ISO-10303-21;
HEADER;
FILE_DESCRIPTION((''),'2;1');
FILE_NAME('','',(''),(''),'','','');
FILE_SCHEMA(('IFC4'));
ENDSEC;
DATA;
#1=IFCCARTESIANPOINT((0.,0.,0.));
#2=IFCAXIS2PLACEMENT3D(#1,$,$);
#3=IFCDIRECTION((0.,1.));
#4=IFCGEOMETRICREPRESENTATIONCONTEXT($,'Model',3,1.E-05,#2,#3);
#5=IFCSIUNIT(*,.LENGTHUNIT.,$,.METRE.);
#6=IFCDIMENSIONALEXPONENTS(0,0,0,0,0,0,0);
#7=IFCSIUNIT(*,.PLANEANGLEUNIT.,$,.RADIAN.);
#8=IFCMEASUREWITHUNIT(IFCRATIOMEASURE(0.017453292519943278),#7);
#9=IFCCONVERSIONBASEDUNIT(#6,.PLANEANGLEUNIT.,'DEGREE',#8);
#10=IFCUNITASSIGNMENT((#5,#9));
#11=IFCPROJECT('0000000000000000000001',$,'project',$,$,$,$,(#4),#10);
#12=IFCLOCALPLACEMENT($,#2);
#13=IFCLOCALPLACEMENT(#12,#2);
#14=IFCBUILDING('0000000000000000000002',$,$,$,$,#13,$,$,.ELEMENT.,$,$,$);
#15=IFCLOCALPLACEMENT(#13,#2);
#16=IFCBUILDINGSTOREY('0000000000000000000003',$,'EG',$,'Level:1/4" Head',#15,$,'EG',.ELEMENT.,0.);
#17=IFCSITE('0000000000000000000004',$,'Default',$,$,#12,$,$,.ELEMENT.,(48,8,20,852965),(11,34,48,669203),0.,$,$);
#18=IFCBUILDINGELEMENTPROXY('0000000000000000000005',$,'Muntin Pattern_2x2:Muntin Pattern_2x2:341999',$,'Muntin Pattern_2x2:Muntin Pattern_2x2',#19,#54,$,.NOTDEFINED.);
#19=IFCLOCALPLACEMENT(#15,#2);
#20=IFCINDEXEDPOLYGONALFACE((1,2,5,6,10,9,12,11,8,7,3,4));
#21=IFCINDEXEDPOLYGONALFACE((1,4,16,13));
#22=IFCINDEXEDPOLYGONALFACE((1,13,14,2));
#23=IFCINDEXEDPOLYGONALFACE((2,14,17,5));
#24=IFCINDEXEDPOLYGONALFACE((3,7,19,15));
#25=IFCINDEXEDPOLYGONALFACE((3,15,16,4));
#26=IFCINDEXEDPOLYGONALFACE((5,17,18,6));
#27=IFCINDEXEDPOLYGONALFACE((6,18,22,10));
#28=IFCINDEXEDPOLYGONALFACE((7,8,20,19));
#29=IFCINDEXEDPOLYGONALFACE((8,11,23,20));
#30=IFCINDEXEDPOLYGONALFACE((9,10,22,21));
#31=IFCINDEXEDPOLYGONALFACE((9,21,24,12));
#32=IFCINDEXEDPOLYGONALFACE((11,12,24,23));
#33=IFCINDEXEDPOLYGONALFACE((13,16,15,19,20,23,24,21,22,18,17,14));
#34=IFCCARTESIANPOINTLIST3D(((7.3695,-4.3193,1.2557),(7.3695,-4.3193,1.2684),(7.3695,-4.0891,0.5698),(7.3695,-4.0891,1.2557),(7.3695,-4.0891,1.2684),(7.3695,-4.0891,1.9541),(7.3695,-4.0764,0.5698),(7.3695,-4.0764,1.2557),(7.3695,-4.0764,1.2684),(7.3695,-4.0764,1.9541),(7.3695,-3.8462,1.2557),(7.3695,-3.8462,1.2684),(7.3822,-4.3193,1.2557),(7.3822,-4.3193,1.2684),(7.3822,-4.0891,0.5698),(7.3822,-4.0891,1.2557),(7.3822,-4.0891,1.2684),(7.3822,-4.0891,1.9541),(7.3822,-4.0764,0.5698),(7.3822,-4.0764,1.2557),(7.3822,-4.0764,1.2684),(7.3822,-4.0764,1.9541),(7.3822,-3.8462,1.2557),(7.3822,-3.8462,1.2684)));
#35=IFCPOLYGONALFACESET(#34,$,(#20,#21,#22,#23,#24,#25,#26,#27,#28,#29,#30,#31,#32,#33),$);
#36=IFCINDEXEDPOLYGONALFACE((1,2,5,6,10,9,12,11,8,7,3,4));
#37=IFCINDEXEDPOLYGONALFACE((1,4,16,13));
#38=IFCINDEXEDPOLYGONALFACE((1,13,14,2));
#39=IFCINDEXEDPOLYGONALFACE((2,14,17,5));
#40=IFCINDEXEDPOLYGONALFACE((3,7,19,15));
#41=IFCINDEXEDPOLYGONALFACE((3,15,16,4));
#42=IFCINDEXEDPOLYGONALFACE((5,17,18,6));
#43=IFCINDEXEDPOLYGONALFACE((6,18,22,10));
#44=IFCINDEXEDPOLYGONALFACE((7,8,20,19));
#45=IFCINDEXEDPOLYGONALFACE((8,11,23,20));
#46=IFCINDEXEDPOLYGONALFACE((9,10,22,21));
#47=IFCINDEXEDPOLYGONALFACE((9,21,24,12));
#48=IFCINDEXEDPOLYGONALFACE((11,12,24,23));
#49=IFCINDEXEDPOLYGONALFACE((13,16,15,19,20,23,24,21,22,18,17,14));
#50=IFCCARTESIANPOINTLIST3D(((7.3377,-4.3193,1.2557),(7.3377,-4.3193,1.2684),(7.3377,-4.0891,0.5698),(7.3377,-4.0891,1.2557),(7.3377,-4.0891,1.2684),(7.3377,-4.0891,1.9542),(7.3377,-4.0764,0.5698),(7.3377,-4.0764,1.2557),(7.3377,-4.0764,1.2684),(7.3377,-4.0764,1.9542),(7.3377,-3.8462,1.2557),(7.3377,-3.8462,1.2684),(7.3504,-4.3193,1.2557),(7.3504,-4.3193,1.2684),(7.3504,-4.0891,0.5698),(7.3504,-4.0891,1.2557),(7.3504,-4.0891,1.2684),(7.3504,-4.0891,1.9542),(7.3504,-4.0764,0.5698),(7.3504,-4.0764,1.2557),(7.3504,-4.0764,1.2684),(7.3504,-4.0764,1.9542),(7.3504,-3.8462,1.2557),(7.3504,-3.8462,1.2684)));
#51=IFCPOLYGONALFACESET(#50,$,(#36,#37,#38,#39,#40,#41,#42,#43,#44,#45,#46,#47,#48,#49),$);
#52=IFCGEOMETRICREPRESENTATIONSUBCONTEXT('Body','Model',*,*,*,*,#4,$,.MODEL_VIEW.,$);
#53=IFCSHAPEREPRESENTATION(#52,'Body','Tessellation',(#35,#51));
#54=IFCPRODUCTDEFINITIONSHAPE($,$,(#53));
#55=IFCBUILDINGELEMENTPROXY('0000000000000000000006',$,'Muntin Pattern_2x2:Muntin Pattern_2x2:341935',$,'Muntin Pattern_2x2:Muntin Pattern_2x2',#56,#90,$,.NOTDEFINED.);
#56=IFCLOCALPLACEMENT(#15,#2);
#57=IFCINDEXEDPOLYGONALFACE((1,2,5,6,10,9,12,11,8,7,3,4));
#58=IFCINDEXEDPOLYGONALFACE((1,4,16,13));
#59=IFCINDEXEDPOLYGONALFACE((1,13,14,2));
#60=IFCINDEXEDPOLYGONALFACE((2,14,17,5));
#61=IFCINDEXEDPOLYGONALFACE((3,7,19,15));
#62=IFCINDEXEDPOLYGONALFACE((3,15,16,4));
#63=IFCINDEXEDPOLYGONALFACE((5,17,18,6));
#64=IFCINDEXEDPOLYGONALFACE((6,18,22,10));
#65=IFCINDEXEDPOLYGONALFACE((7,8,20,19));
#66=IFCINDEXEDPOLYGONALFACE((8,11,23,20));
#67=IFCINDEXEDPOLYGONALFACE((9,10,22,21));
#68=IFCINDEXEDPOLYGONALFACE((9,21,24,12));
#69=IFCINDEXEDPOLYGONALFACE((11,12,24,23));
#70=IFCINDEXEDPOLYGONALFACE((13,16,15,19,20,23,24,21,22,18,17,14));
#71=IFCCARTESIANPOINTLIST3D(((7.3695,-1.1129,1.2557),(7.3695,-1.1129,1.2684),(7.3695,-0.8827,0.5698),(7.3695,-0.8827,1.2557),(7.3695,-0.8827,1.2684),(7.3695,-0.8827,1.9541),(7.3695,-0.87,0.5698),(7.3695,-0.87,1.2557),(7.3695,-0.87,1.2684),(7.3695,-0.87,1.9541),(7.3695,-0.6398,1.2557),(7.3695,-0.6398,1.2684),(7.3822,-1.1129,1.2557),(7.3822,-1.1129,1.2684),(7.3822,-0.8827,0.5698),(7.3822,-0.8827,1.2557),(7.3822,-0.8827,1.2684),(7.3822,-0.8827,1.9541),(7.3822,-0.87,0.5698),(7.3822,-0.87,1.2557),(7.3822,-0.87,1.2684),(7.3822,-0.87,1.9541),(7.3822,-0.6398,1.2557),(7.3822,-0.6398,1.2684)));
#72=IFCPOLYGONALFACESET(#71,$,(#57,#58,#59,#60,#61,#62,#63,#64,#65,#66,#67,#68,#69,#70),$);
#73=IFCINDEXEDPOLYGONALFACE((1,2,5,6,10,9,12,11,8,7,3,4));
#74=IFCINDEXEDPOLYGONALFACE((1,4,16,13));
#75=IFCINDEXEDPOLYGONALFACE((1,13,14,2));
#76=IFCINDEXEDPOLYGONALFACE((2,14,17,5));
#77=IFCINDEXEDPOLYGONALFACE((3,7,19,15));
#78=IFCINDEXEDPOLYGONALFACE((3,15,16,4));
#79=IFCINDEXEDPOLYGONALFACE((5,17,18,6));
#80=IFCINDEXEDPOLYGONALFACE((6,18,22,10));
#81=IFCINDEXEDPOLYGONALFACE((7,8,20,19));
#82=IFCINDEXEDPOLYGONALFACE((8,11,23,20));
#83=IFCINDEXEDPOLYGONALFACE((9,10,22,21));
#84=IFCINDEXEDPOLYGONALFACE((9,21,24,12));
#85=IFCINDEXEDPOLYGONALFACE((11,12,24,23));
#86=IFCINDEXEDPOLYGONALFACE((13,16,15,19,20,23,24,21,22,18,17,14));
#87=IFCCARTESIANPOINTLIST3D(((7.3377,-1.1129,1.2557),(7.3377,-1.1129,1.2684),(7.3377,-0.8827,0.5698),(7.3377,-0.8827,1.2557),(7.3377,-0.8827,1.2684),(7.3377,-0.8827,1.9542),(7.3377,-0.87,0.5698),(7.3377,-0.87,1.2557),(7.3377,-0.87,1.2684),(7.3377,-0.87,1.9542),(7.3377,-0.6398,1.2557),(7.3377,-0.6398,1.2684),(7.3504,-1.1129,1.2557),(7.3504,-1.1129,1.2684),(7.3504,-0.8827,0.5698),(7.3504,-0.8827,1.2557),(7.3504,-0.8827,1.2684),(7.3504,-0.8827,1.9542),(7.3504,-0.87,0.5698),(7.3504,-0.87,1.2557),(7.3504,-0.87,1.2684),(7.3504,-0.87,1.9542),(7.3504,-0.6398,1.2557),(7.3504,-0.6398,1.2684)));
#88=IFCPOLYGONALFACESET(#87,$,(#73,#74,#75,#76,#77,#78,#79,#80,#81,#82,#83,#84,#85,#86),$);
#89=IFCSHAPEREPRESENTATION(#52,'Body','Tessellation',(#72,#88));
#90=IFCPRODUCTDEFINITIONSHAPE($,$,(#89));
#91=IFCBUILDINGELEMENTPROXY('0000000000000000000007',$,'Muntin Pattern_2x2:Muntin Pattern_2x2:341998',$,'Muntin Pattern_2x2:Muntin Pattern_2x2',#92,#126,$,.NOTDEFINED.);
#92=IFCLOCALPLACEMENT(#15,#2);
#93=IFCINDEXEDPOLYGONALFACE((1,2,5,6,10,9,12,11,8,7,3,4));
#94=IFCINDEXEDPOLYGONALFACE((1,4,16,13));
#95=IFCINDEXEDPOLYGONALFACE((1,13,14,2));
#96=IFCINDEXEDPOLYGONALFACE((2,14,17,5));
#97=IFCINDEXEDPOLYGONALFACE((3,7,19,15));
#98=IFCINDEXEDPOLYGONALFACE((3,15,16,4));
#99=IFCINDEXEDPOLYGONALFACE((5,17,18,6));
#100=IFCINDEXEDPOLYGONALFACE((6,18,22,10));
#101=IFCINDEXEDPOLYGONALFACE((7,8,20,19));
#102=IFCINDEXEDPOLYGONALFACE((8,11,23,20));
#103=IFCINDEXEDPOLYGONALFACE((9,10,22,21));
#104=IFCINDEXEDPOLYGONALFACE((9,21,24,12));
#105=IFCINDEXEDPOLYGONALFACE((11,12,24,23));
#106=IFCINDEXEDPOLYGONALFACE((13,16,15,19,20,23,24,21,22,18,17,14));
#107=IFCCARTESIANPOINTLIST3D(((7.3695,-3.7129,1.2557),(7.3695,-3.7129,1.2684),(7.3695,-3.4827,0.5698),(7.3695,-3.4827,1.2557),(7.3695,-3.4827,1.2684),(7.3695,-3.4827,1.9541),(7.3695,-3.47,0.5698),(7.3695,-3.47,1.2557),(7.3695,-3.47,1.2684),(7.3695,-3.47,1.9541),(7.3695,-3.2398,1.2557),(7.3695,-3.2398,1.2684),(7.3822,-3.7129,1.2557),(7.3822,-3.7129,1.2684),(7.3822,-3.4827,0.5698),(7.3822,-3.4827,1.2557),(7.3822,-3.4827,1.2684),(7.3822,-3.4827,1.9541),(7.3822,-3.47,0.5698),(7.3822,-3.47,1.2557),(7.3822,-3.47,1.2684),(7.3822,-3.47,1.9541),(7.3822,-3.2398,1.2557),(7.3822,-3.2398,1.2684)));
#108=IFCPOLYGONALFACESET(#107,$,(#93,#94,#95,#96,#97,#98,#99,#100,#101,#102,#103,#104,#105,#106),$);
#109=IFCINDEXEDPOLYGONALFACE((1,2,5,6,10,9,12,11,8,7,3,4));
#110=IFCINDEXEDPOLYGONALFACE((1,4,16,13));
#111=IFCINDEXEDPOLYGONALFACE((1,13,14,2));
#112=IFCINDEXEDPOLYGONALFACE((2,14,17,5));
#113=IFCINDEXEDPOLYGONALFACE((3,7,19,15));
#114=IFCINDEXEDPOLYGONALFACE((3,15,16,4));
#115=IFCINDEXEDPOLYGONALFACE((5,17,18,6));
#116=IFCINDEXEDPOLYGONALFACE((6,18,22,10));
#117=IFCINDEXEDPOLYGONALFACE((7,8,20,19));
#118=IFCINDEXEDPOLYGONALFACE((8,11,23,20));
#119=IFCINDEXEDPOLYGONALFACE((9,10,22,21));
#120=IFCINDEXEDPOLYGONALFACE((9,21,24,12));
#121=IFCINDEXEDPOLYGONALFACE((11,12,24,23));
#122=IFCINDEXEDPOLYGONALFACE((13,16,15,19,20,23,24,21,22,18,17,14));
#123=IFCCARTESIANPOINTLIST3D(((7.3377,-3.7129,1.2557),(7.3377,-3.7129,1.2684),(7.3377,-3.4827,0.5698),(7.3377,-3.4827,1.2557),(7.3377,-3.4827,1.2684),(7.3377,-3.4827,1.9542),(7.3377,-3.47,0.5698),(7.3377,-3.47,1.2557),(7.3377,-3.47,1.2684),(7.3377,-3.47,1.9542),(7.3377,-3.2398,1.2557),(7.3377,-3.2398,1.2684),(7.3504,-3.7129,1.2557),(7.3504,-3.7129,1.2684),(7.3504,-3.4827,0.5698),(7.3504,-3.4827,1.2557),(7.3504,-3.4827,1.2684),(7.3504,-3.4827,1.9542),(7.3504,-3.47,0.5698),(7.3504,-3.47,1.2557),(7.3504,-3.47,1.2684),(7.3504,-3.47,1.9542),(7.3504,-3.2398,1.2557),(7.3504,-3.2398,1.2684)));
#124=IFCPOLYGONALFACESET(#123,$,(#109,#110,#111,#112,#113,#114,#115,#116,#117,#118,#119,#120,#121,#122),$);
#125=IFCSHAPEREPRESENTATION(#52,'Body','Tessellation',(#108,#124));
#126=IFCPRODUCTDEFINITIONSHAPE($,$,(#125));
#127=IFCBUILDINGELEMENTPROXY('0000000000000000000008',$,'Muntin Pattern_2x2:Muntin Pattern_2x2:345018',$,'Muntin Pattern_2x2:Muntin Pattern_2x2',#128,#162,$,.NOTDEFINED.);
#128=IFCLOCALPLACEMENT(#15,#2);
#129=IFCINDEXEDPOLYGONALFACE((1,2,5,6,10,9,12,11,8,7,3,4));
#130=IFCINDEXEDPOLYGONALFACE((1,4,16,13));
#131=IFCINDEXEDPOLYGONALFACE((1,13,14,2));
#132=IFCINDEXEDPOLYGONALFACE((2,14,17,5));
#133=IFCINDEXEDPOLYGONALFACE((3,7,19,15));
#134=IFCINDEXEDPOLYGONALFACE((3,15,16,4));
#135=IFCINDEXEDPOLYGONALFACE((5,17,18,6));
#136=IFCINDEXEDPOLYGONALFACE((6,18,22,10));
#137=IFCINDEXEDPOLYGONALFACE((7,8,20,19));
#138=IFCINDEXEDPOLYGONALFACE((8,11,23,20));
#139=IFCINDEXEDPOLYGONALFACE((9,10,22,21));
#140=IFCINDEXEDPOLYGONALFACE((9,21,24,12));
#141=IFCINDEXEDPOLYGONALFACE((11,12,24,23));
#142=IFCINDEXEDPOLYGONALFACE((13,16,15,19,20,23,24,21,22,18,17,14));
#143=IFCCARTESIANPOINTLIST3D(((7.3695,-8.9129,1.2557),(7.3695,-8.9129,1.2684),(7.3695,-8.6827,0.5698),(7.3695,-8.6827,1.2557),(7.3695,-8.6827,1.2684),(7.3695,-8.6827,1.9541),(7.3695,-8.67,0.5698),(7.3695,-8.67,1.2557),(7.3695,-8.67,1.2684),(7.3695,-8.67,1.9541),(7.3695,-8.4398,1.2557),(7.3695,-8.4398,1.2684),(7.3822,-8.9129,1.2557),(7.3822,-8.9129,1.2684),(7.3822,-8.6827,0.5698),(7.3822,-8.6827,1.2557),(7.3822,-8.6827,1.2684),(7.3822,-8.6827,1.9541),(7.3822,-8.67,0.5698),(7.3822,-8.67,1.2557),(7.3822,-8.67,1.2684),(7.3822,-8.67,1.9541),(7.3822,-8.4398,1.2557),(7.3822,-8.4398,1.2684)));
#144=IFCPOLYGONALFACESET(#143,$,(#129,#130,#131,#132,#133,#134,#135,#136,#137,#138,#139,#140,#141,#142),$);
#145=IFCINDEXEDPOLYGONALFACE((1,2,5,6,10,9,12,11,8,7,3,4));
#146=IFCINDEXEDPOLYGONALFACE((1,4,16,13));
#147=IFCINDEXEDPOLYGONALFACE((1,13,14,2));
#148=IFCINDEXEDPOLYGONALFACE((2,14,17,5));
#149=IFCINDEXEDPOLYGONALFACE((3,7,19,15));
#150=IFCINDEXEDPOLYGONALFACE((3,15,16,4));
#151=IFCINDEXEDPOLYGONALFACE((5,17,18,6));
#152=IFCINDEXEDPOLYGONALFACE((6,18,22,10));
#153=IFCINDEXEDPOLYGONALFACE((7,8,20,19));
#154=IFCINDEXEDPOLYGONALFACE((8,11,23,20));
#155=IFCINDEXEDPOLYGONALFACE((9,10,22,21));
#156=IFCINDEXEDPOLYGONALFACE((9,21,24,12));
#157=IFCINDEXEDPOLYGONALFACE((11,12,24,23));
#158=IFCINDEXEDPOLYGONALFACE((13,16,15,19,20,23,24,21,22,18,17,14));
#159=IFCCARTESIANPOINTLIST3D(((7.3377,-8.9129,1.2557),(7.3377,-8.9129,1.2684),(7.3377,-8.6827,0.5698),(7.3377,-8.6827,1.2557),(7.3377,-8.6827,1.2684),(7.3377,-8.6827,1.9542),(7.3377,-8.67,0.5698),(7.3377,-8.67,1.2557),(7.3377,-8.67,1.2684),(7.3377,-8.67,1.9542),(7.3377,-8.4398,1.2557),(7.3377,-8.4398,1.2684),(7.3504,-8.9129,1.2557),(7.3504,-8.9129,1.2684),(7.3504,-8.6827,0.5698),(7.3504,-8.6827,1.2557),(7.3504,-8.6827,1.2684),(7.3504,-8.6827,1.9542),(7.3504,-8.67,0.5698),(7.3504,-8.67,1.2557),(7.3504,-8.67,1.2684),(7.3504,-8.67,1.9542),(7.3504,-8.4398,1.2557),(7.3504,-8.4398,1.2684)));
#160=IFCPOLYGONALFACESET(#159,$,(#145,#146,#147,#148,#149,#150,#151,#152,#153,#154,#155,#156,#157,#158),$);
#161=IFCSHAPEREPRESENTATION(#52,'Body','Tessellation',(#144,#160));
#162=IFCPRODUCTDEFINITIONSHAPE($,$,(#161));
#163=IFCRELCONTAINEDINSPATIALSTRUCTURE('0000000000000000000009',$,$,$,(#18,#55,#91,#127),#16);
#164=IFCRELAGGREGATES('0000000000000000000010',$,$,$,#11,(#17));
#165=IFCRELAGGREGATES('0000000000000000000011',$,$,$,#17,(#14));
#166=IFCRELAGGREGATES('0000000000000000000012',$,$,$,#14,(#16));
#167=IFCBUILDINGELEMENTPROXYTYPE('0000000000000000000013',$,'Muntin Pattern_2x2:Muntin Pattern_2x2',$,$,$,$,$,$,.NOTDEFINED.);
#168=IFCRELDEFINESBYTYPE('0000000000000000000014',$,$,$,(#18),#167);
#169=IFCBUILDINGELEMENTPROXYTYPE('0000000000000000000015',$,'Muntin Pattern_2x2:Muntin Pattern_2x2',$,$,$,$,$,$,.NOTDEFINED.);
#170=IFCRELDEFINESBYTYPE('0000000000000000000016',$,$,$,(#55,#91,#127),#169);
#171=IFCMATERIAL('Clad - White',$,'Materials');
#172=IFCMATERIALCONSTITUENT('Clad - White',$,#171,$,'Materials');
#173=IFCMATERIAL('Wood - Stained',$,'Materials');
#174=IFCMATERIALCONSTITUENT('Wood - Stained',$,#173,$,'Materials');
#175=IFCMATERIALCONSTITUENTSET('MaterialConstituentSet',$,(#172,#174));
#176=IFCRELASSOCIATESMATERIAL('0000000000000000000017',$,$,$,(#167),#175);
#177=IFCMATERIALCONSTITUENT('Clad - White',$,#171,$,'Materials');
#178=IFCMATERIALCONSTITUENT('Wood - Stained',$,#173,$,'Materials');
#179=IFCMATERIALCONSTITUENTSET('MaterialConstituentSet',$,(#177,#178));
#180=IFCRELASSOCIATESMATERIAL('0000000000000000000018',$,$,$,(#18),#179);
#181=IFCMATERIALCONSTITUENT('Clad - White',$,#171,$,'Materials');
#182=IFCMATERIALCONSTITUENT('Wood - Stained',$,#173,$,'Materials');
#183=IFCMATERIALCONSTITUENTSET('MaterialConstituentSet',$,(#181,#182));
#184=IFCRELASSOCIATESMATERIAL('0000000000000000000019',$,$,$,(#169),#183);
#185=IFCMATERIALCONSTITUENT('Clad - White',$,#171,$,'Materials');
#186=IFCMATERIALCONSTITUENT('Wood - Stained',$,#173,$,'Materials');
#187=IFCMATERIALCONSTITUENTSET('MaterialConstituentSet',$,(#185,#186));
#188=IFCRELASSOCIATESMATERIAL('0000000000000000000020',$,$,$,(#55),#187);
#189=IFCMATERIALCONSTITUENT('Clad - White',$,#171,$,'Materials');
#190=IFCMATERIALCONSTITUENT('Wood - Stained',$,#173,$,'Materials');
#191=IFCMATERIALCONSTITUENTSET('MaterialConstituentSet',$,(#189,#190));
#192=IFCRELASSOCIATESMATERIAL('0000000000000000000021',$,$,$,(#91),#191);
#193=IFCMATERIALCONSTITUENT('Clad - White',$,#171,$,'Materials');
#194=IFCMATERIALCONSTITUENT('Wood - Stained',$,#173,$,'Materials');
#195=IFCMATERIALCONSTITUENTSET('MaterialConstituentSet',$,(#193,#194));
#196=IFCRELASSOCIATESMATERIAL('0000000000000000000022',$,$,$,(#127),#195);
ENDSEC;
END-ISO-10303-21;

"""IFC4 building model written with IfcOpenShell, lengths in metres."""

from ifc_helpers import new_model, entity, si_unit, converted_unit, direction, frame, origin, place, context, subcontext, project, spatial, indexed_curve, outline, extrude, source, transform, mapped, material, constituent, constituent_set, type_object, type_shapes, element, save


model = new_model("IFC4")

# Units and contexts
model_context = context("Model", 3, precision=1e-05, world=origin(), true_north=direction((0.0, 1.0)))
body_context = subcontext(model_context, "Body", "Model", "MODEL_VIEW")
ifc_project = project(units=[si_unit("LENGTHUNIT", "METRE"), converted_unit("PLANEANGLEUNIT", "DEGREE", entity("IfcRatioMeasure", 0.017453292519943278), si_unit("PLANEANGLEUNIT", "RADIAN"), dimensions=[0, 0, 0, 0, 0, 0, 0])], contexts=[model_context])

# Site, building, storey
site_placement = place(None, origin())
site = spatial("IfcSite", under=ifc_project, at=site_placement, Name="Default", CompositionType="ELEMENT", RefLatitude=(48, 8, 20, 852965), RefLongitude=(11, 34, 48, 669203), RefElevation=0.0)
building_placement = place(site_placement, origin())
building = spatial("IfcBuilding", under=site, at=building_placement, CompositionType="ELEMENT")
storey_placement = place(building_placement, origin())
storey = spatial("IfcBuildingStorey", under=building, at=storey_placement, Name="EG", ObjectType="Level:1/4\" Head", LongName="EG", CompositionType="ELEMENT", Elevation=0.0)

# Building element proxies
ifc_material_1 = material(Name="Clad - White", Category="Materials")
ifc_material_2 = material(Name="Wood - Stained", Category="Materials")
ifc_constituent_1 = constituent(ifc_material_1, Name="Clad - White", Category="Materials")
ifc_constituent_2 = constituent(ifc_material_2, Name="Wood - Stained", Category="Materials")
ifc_constituent_set_1 = constituent_set(constituents=[ifc_constituent_1, ifc_constituent_2], Name="MaterialConstituentSet")
building_element_proxy_type_1 = type_object("IfcBuildingElementProxyType", Name="Muntin Pattern_2x2:Muntin Pattern_2x2", PredefinedType="NOTDEFINED", material=ifc_constituent_set_1)
shared_shape_1 = source(origin(), body_context, "Body", "SweptSolid", [
    extrude(outline(indexed_curve([(0.0064, -0.0064), (0.6921, -0.0064), (0.6921, 0.0063), (0.0064, 0.0063), (0.0064, 0.2365), (-0.0063, 0.2365), (-0.0063, 0.0063), (-0.6922, 0.0063), (-0.6922, -0.0064), (-0.0063, -0.0064), (-0.0063, -0.2365), (0.0064, -0.2365), (0.0064, -0.0064)], self_intersect=False)), frame((0.0, -0.0222, 0.6921), z_axis=(0.0, 1.0, 0.0), x_axis=(0.0, 0.0, 1.0)), (0.0, 0.0, 1.0), 0.0127),
    extrude(outline(indexed_curve([(0.0064, -0.0064), (0.6922, -0.0064), (0.6922, 0.0063), (0.0064, 0.0063), (0.0064, 0.2365), (-0.0063, 0.2365), (-0.0063, 0.0063), (-0.6922, 0.0063), (-0.6922, -0.0064), (-0.0063, -0.0064), (-0.0063, -0.2365), (0.0064, -0.2365), (0.0064, -0.0064)], self_intersect=False)), frame((0.0, 0.0095, 0.6922), z_axis=(0.0, 1.0, 0.0), x_axis=(0.0, 0.0, 1.0)), (0.0, 0.0, 1.0), 0.0127),
])
type_shapes(building_element_proxy_type_1, [shared_shape_1])
ifc_constituent_3 = constituent(ifc_material_1, Name="Clad - White", Category="Materials")
ifc_constituent_4 = constituent(ifc_material_2, Name="Wood - Stained", Category="Materials")
ifc_constituent_set_2 = constituent_set(constituents=[ifc_constituent_3, ifc_constituent_4], Name="MaterialConstituentSet")
proxy_1_placement = place(storey_placement, frame((7.3599, -4.0828, 0.5699), z_axis=(0.0, 0.0, 1.0), x_axis=(0.0, 1.0, 0.0)))
element("IfcBuildingElementProxy", 1, at=proxy_1_placement, inside=storey, type_object=building_element_proxy_type_1, material=ifc_constituent_set_2, Name="Muntin Pattern_2x2:Muntin Pattern_2x2:341999", ObjectType="Muntin Pattern_2x2:Muntin Pattern_2x2", PredefinedType="NOTDEFINED", context=body_context, shape_type="MappedRepresentation", body=[
    mapped(shared_shape_1, transform((0.0, 0.0, 0.0), scale=1.0)),
])
ifc_constituent_5 = constituent(ifc_material_1, Name="Clad - White", Category="Materials")
ifc_constituent_6 = constituent(ifc_material_2, Name="Wood - Stained", Category="Materials")
ifc_constituent_set_3 = constituent_set(constituents=[ifc_constituent_5, ifc_constituent_6], Name="MaterialConstituentSet")
ifc_constituent_7 = constituent(ifc_material_1, Name="Clad - White", Category="Materials")
ifc_constituent_8 = constituent(ifc_material_2, Name="Wood - Stained", Category="Materials")
ifc_constituent_set_4 = constituent_set(constituents=[ifc_constituent_7, ifc_constituent_8], Name="MaterialConstituentSet")
building_element_proxy_type_2 = type_object("IfcBuildingElementProxyType", Name="Muntin Pattern_2x2:Muntin Pattern_2x2", PredefinedType="NOTDEFINED", material=ifc_constituent_set_4)
shared_shape_2 = source(origin(), body_context, "Body", "SweptSolid", [
    extrude(outline(indexed_curve([(0.0064, -0.0064), (0.6921, -0.0064), (0.6921, 0.0063), (0.0064, 0.0063), (0.0064, 0.2365), (-0.0063, 0.2365), (-0.0063, 0.0063), (-0.6922, 0.0063), (-0.6922, -0.0064), (-0.0063, -0.0064), (-0.0063, -0.2365), (0.0064, -0.2365), (0.0064, -0.0064)], self_intersect=False)), frame((0.0, 0.0095, 0.6921), z_axis=(0.0, 1.0, 0.0), x_axis=(0.0, 0.0, 1.0)), (0.0, 0.0, 1.0), 0.0127),
    extrude(outline(indexed_curve([(0.0064, -0.0064), (0.6922, -0.0064), (0.6922, 0.0063), (0.0064, 0.0063), (0.0064, 0.2365), (-0.0063, 0.2365), (-0.0063, 0.0063), (-0.6922, 0.0063), (-0.6922, -0.0064), (-0.0063, -0.0064), (-0.0063, -0.2365), (0.0064, -0.2365), (0.0064, -0.0064)], self_intersect=False)), frame((0.0, -0.0222, 0.6922), z_axis=(0.0, 1.0, 0.0), x_axis=(0.0, 0.0, 1.0)), (0.0, 0.0, 1.0), 0.0127),
])
type_shapes(building_element_proxy_type_2, [shared_shape_2])
proxy_2_placement = place(storey_placement, frame((7.3599, -0.8763, 0.5699), z_axis=(0.0, 0.0, 1.0), x_axis=(0.0, -1.0, 0.0)))
element("IfcBuildingElementProxy", 2, at=proxy_2_placement, inside=storey, type_object=building_element_proxy_type_2, material=ifc_constituent_set_3, Name="Muntin Pattern_2x2:Muntin Pattern_2x2:341935", ObjectType="Muntin Pattern_2x2:Muntin Pattern_2x2", PredefinedType="NOTDEFINED", context=body_context, shape_type="MappedRepresentation", body=[
    mapped(shared_shape_2, transform((0.0, 0.0, 0.0), scale=1.0)),
])
ifc_constituent_9 = constituent(ifc_material_1, Name="Clad - White", Category="Materials")
ifc_constituent_10 = constituent(ifc_material_2, Name="Wood - Stained", Category="Materials")
ifc_constituent_set_5 = constituent_set(constituents=[ifc_constituent_9, ifc_constituent_10], Name="MaterialConstituentSet")
proxy_3_placement = place(storey_placement, frame((7.3599, -3.4763, 0.5699), z_axis=(0.0, 0.0, 1.0), x_axis=(0.0, -1.0, 0.0)))
element("IfcBuildingElementProxy", 3, at=proxy_3_placement, inside=storey, type_object=building_element_proxy_type_2, material=ifc_constituent_set_5, Name="Muntin Pattern_2x2:Muntin Pattern_2x2:341998", ObjectType="Muntin Pattern_2x2:Muntin Pattern_2x2", PredefinedType="NOTDEFINED", context=body_context, shape_type="MappedRepresentation", body=[
    mapped(shared_shape_2, transform((0.0, 0.0, 0.0), scale=1.0)),
])
ifc_constituent_11 = constituent(ifc_material_1, Name="Clad - White", Category="Materials")
ifc_constituent_12 = constituent(ifc_material_2, Name="Wood - Stained", Category="Materials")
ifc_constituent_set_6 = constituent_set(constituents=[ifc_constituent_11, ifc_constituent_12], Name="MaterialConstituentSet")
proxy_4_placement = place(storey_placement, frame((7.3599, -8.6763, 0.5699), z_axis=(0.0, 0.0, 1.0), x_axis=(0.0, -1.0, 0.0)))
element("IfcBuildingElementProxy", 4, at=proxy_4_placement, inside=storey, type_object=building_element_proxy_type_2, material=ifc_constituent_set_6, Name="Muntin Pattern_2x2:Muntin Pattern_2x2:345018", ObjectType="Muntin Pattern_2x2:Muntin Pattern_2x2", PredefinedType="NOTDEFINED", context=body_context, shape_type="MappedRepresentation", body=[
    mapped(shared_shape_2, transform((0.0, 0.0, 0.0), scale=1.0)),
])

save(model, "model.ifc")
